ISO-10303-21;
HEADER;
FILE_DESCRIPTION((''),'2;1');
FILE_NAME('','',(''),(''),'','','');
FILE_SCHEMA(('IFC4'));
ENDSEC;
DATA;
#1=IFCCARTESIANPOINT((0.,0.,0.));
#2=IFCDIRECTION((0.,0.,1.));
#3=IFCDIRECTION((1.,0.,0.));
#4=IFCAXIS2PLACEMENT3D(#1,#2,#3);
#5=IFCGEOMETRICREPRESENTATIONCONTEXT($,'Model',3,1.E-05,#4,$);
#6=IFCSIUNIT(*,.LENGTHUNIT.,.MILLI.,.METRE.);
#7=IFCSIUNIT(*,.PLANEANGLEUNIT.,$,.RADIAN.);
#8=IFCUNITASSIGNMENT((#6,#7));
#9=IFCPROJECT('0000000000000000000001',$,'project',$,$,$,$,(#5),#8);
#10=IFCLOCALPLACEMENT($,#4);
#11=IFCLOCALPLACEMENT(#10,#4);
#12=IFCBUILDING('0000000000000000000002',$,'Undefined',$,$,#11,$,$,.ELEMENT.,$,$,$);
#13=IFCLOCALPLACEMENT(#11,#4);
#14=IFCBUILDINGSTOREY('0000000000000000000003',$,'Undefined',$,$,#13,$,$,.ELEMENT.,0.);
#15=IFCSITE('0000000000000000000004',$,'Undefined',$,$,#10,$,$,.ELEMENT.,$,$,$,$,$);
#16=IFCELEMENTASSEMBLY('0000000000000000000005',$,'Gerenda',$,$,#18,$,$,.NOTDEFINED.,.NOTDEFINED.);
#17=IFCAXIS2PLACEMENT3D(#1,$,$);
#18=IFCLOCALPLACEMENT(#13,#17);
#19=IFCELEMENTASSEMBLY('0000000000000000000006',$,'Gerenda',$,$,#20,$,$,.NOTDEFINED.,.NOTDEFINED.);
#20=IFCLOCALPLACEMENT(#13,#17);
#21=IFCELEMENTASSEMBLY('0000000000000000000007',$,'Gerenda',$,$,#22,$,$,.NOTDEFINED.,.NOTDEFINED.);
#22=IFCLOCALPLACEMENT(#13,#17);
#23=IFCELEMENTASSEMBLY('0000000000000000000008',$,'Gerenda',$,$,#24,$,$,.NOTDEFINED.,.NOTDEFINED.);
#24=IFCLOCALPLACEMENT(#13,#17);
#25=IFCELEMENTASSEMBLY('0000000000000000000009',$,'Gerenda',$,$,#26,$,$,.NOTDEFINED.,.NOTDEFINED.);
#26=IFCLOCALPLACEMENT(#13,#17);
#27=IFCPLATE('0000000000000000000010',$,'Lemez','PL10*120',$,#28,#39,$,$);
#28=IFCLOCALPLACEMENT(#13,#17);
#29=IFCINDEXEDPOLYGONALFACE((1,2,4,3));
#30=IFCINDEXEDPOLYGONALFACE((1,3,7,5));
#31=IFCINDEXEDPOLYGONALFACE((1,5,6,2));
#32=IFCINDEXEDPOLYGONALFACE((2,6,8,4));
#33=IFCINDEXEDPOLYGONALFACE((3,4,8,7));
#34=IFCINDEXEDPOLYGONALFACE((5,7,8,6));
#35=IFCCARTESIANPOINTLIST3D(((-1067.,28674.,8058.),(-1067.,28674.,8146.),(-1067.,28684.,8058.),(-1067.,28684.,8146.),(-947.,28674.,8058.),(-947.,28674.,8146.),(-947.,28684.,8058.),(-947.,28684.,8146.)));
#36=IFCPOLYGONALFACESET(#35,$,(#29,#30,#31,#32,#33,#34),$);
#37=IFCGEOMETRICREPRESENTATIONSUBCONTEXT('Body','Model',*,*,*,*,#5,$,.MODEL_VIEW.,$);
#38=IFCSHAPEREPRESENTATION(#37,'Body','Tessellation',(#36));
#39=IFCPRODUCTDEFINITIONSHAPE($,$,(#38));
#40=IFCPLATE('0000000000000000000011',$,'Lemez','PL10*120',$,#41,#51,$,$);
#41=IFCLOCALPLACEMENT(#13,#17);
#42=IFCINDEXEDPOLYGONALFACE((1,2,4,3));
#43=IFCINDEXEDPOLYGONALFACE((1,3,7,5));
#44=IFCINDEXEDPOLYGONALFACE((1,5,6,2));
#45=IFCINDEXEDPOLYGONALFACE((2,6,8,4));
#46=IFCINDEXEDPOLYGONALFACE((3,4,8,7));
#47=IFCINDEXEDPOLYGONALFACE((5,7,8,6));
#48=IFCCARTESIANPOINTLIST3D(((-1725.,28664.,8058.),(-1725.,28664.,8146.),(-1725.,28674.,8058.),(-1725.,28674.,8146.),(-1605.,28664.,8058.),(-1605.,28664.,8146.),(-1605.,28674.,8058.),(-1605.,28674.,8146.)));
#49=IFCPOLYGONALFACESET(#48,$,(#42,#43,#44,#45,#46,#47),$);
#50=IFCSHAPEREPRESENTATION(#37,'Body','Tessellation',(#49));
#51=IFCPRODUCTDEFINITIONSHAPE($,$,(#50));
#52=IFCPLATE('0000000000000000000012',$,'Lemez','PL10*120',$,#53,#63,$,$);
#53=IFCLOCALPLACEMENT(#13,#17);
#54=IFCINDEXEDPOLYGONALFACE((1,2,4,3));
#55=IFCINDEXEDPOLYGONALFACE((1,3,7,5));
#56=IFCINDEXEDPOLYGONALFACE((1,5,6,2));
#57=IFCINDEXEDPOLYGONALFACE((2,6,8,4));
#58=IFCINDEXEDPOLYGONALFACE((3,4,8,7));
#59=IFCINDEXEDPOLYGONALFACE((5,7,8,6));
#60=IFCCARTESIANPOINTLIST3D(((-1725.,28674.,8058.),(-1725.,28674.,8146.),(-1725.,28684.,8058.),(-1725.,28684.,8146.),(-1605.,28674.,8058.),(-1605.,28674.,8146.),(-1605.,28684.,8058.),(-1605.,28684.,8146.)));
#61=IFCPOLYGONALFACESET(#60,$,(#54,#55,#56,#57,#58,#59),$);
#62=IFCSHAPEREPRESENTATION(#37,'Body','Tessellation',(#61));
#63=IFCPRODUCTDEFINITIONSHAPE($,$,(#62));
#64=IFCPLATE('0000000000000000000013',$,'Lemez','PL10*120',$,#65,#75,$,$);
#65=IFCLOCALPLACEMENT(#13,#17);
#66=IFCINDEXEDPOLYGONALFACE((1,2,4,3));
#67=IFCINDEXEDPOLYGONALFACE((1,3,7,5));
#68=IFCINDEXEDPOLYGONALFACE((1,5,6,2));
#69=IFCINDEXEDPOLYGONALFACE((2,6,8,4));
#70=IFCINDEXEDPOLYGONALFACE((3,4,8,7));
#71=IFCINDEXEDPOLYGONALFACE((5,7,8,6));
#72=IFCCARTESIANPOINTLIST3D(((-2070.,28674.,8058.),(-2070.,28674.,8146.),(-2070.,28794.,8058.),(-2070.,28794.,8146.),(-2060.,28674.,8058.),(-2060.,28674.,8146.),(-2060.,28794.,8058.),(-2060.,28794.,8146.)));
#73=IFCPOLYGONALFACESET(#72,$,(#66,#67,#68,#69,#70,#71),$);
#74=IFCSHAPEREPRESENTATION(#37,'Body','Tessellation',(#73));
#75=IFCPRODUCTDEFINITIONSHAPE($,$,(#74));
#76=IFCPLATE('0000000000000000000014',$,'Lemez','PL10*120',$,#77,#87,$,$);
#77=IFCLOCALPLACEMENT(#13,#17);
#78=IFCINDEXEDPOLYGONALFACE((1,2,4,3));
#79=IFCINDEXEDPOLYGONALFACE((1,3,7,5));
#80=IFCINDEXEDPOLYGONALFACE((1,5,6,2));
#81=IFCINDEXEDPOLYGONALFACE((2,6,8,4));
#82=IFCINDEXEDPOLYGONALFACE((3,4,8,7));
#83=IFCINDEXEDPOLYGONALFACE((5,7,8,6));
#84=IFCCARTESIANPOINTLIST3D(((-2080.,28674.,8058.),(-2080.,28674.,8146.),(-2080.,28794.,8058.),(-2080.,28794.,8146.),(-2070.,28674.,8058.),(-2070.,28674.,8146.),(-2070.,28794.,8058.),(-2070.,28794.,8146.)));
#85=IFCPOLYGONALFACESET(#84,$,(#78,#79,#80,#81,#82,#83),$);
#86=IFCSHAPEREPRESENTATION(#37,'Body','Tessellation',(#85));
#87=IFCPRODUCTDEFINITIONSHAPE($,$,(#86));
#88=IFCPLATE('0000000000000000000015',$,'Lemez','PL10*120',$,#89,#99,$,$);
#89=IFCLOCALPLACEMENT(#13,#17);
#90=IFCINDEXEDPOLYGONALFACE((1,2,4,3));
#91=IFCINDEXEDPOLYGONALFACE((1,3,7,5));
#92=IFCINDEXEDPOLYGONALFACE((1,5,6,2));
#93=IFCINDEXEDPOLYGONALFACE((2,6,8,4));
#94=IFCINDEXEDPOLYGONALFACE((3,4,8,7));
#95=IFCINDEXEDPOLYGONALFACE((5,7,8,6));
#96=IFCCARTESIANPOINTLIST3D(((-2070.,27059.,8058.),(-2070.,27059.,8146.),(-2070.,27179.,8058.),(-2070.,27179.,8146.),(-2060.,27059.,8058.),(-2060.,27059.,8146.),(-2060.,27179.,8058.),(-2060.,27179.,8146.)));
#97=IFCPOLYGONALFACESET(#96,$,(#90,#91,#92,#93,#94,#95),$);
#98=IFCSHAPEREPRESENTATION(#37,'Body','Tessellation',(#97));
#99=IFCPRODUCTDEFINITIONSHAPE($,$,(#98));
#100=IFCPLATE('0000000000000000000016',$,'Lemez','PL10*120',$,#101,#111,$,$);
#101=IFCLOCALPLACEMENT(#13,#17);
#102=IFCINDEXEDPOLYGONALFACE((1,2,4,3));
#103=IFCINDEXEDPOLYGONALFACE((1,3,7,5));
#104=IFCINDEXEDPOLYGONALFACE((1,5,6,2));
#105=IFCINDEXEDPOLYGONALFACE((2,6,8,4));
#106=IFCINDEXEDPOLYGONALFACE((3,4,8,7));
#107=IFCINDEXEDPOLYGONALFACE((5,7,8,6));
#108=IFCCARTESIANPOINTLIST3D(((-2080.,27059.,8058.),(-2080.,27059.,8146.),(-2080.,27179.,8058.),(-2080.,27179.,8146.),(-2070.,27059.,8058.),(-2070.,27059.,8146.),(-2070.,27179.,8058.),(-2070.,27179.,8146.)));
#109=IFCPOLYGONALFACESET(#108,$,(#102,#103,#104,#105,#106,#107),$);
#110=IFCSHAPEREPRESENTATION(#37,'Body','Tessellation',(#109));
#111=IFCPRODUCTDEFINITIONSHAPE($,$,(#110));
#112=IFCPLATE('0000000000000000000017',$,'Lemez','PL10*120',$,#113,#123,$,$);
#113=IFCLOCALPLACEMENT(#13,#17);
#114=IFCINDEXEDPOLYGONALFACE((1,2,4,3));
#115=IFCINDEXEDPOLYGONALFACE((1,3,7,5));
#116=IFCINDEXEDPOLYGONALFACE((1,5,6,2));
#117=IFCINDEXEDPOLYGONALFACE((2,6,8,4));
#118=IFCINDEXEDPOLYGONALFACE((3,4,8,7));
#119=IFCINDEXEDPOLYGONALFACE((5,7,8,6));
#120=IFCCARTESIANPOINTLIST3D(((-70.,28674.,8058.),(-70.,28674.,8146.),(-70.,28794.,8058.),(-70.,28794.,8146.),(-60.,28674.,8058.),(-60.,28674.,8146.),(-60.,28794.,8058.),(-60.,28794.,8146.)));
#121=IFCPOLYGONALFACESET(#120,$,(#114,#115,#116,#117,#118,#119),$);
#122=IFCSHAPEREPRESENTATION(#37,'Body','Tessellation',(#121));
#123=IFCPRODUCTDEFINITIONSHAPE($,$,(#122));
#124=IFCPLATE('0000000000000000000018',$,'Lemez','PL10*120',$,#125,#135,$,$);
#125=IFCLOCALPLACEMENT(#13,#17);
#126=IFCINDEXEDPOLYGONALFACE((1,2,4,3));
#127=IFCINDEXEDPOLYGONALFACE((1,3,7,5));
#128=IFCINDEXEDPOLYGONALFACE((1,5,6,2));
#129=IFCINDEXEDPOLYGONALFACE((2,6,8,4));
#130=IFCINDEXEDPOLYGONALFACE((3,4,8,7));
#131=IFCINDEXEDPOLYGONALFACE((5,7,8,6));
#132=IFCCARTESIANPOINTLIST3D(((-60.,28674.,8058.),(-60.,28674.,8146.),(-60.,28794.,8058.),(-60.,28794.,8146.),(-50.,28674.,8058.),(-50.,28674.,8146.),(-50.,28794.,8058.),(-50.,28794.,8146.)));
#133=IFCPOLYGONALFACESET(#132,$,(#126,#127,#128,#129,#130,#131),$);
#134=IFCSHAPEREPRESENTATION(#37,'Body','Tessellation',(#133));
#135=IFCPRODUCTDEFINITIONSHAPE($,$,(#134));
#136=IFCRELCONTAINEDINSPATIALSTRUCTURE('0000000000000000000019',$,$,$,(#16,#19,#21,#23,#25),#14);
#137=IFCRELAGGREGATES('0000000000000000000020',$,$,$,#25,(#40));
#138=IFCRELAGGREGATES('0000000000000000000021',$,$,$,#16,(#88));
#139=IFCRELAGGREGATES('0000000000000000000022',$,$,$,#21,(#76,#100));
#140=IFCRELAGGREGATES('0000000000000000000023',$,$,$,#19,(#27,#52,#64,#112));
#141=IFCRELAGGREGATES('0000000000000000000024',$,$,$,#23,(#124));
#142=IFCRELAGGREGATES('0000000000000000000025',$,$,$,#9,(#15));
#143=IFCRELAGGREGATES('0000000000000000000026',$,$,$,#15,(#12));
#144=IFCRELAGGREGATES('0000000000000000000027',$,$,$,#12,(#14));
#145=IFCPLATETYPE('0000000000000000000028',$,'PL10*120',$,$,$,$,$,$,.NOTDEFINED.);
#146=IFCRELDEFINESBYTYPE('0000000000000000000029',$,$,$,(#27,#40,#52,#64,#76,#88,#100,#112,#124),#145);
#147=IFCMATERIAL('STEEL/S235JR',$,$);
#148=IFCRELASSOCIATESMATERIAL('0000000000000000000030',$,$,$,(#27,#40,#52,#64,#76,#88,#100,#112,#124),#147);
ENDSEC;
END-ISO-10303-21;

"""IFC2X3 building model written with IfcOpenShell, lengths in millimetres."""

from ifc_helpers import new_model, si_unit, frame, origin_with_axes, place, context, subcontext, project, spatial, polyline, outline, extrude, material, type_object, element, aggregate, save


model = new_model("IFC2X3")

# Units and contexts
model_context = context("Model", 3, precision=1e-05, world=origin_with_axes())
body_context = subcontext(model_context, "Body", "Model", "MODEL_VIEW")
ifc_project = project(units=[si_unit("LENGTHUNIT", "METRE", prefix="MILLI"), si_unit("PLANEANGLEUNIT", "RADIAN")], contexts=[model_context])

# Site, building, storey
site_placement = place(None, origin_with_axes())
site = spatial("IfcSite", under=ifc_project, at=site_placement, Name="Undefined", CompositionType="ELEMENT")
building_placement = place(site_placement, origin_with_axes())
building = spatial("IfcBuilding", under=site, at=building_placement, Name="Undefined", CompositionType="ELEMENT")
storey_placement = place(building_placement, origin_with_axes())
storey = spatial("IfcBuildingStorey", under=building, at=storey_placement, Name="Undefined", CompositionType="ELEMENT", Elevation=0.0)

# Element assemblies
assembly_1_placement = place(storey_placement, origin_with_axes())
assembly_1 = element("IfcElementAssembly", 1, at=assembly_1_placement, inside=storey, Name="Gerenda", AssemblyPlace="NOTDEFINED", PredefinedType="NOTDEFINED")
ifc_material = material(Name="STEEL/S235JR")
assembly_2_placement = place(storey_placement, origin_with_axes())
assembly_2 = element("IfcElementAssembly", 2, at=assembly_2_placement, inside=storey, Name="Gerenda", AssemblyPlace="NOTDEFINED", PredefinedType="NOTDEFINED")
assembly_3_placement = place(storey_placement, origin_with_axes())
assembly_3 = element("IfcElementAssembly", 3, at=assembly_3_placement, inside=storey, Name="Gerenda", AssemblyPlace="NOTDEFINED", PredefinedType="NOTDEFINED")
assembly_4_placement = place(storey_placement, origin_with_axes())
assembly_4 = element("IfcElementAssembly", 4, at=assembly_4_placement, inside=storey, Name="Gerenda", AssemblyPlace="NOTDEFINED", PredefinedType="NOTDEFINED")

# Element assembly
assembly_5_placement = place(storey_placement, origin_with_axes())
assembly_5 = element("IfcElementAssembly", 5, at=assembly_5_placement, inside=storey, Name="Gerenda", AssemblyPlace="NOTDEFINED", PredefinedType="NOTDEFINED")
plate_type_1 = type_object("IfcPlateType", Name="PL10*120", PredefinedType="NOTDEFINED")

# Plates
plate_1_placement = place(assembly_2_placement, frame((-1007.0, 28679.0, 8058.0), z_axis=(-0.000003, -1.0, 0.0), x_axis=(0.0, 0.0, 1.0)))
plate_1 = element("IfcPlate", 6, at=plate_1_placement, type_object=plate_type_1, material=ifc_material, Name="Lemez", Description="PL10*120", context=body_context, shape_type="SweptSolid", body=[
    extrude(outline(polyline([(0.0, -60.0), (0.0, 60.0), (88.0, 60.0), (88.0, -60.0), (0.0, -60.0)])), frame((0.0, 0.0, -5.0), z_axis=(0.0, 0.0, 1.0), x_axis=(1.0, 0.0, 0.0)), (0.0, 0.0, 1.0), 10.0),
])
plate_2_placement = place(assembly_5_placement, frame((-1665.0, 28669.0, 8058.0), z_axis=(-0.000003, -1.0, 0.0), x_axis=(0.0, 0.0, 1.0)))
plate_2 = element("IfcPlate", 7, at=plate_2_placement, type_object=plate_type_1, material=ifc_material, Name="Lemez", Description="PL10*120", context=body_context, shape_type="SweptSolid", body=[
    extrude(outline(polyline([(0.0, -60.0), (0.0, 60.0), (88.0, 60.0), (88.0, -60.0), (0.0, -60.0)])), frame((0.0, 0.0, -5.0), z_axis=(0.0, 0.0, 1.0), x_axis=(1.0, 0.0, 0.0)), (0.0, 0.0, 1.0), 10.0),
])
aggregate(assembly_5, [plate_2])
plate_3_placement = place(assembly_2_placement, frame((-1665.0, 28679.0, 8058.0), z_axis=(-0.000003, -1.0, 0.0), x_axis=(0.0, 0.0, 1.0)))
plate_3 = element("IfcPlate", 8, at=plate_3_placement, type_object=plate_type_1, material=ifc_material, Name="Lemez", Description="PL10*120", context=body_context, shape_type="SweptSolid", body=[
    extrude(outline(polyline([(0.0, -60.0), (0.0, 60.0), (88.0, 60.0), (88.0, -60.0), (0.0, -60.0)])), frame((0.0, 0.0, -5.0), z_axis=(0.0, 0.0, 1.0), x_axis=(1.0, 0.0, 0.0)), (0.0, 0.0, 1.0), 10.0),
])
plate_4_placement = place(assembly_2_placement, frame((-2065.0, 28734.0, 8058.0), z_axis=(1.0, -0.000004, 0.0), x_axis=(0.0, 0.0, 1.0)))
plate_4 = element("IfcPlate", 9, at=plate_4_placement, type_object=plate_type_1, material=ifc_material, Name="Lemez", Description="PL10*120", context=body_context, shape_type="SweptSolid", body=[
    extrude(outline(polyline([(0.0, -60.0), (0.0, 60.0), (88.0, 60.0), (88.0, -60.0), (0.0, -60.0)])), frame((0.0, 0.0, -5.0), z_axis=(0.0, 0.0, 1.0), x_axis=(1.0, 0.0, 0.0)), (0.0, 0.0, 1.0), 10.0),
])
plate_5_placement = place(assembly_3_placement, frame((-2075.0, 28734.0, 8058.0), z_axis=(1.0, -0.000004, 0.0), x_axis=(0.0, 0.0, 1.0)))
plate_5 = element("IfcPlate", 10, at=plate_5_placement, type_object=plate_type_1, material=ifc_material, Name="Lemez", Description="PL10*120", context=body_context, shape_type="SweptSolid", body=[
    extrude(outline(polyline([(0.0, -60.0), (0.0, 60.0), (88.0, 60.0), (88.0, -60.0), (0.0, -60.0)])), frame((0.0, 0.0, -5.0), z_axis=(0.0, 0.0, 1.0), x_axis=(1.0, 0.0, 0.0)), (0.0, 0.0, 1.0), 10.0),
])
plate_6_placement = place(assembly_1_placement, frame((-2065.0, 27119.0, 8058.0), z_axis=(1.0, -0.000004, 0.0), x_axis=(0.0, 0.0, 1.0)))
plate_6 = element("IfcPlate", 11, at=plate_6_placement, type_object=plate_type_1, material=ifc_material, Name="Lemez", Description="PL10*120", context=body_context, shape_type="SweptSolid", body=[
    extrude(outline(polyline([(0.0, -60.0), (0.0, 60.0), (88.0, 60.0), (88.0, -60.0), (0.0, -60.0)])), frame((0.0, 0.0, -5.0), z_axis=(0.0, 0.0, 1.0), x_axis=(1.0, 0.0, 0.0)), (0.0, 0.0, 1.0), 10.0),
])
aggregate(assembly_1, [plate_6])
plate_7_placement = place(assembly_3_placement, frame((-2075.0, 27119.0, 8058.0), z_axis=(1.0, -0.000004, 0.0), x_axis=(0.0, 0.0, 1.0)))
plate_7 = element("IfcPlate", 12, at=plate_7_placement, type_object=plate_type_1, material=ifc_material, Name="Lemez", Description="PL10*120", context=body_context, shape_type="SweptSolid", body=[
    extrude(outline(polyline([(0.0, -60.0), (0.0, 60.0), (88.0, 60.0), (88.0, -60.0), (0.0, -60.0)])), frame((0.0, 0.0, -5.0), z_axis=(0.0, 0.0, 1.0), x_axis=(1.0, 0.0, 0.0)), (0.0, 0.0, 1.0), 10.0),
])
aggregate(assembly_3, [plate_5, plate_7])
plate_8_placement = place(assembly_2_placement, frame((-65.0, 28734.0, 8058.0), z_axis=(-1.0, 0.000003, 0.0), x_axis=(0.0, 0.0, 1.0)))
plate_8 = element("IfcPlate", 13, at=plate_8_placement, type_object=plate_type_1, material=ifc_material, Name="Lemez", Description="PL10*120", context=body_context, shape_type="SweptSolid", body=[
    extrude(outline(polyline([(0.0, -60.0), (0.0, 60.0), (88.0, 60.0), (88.0, -60.0), (0.0, -60.0)])), frame((0.0, 0.0, -5.0), z_axis=(0.0, 0.0, 1.0), x_axis=(1.0, 0.0, 0.0)), (0.0, 0.0, 1.0), 10.0),
])
aggregate(assembly_2, [plate_1, plate_3, plate_4, plate_8])
plate_9_placement = place(assembly_4_placement, frame((-55.0, 28734.0, 8058.0), z_axis=(-1.0, 0.000003, 0.0), x_axis=(0.0, 0.0, 1.0)))
plate_9 = element("IfcPlate", 14, at=plate_9_placement, type_object=plate_type_1, material=ifc_material, Name="Lemez", Description="PL10*120", context=body_context, shape_type="SweptSolid", body=[
    extrude(outline(polyline([(0.0, -60.0), (0.0, 60.0), (88.0, 60.0), (88.0, -60.0), (0.0, -60.0)])), frame((0.0, 0.0, -5.0), z_axis=(0.0, 0.0, 1.0), x_axis=(1.0, 0.0, 0.0)), (0.0, 0.0, 1.0), 10.0),
])
aggregate(assembly_4, [plate_9])

save(model, "model.ifc")
